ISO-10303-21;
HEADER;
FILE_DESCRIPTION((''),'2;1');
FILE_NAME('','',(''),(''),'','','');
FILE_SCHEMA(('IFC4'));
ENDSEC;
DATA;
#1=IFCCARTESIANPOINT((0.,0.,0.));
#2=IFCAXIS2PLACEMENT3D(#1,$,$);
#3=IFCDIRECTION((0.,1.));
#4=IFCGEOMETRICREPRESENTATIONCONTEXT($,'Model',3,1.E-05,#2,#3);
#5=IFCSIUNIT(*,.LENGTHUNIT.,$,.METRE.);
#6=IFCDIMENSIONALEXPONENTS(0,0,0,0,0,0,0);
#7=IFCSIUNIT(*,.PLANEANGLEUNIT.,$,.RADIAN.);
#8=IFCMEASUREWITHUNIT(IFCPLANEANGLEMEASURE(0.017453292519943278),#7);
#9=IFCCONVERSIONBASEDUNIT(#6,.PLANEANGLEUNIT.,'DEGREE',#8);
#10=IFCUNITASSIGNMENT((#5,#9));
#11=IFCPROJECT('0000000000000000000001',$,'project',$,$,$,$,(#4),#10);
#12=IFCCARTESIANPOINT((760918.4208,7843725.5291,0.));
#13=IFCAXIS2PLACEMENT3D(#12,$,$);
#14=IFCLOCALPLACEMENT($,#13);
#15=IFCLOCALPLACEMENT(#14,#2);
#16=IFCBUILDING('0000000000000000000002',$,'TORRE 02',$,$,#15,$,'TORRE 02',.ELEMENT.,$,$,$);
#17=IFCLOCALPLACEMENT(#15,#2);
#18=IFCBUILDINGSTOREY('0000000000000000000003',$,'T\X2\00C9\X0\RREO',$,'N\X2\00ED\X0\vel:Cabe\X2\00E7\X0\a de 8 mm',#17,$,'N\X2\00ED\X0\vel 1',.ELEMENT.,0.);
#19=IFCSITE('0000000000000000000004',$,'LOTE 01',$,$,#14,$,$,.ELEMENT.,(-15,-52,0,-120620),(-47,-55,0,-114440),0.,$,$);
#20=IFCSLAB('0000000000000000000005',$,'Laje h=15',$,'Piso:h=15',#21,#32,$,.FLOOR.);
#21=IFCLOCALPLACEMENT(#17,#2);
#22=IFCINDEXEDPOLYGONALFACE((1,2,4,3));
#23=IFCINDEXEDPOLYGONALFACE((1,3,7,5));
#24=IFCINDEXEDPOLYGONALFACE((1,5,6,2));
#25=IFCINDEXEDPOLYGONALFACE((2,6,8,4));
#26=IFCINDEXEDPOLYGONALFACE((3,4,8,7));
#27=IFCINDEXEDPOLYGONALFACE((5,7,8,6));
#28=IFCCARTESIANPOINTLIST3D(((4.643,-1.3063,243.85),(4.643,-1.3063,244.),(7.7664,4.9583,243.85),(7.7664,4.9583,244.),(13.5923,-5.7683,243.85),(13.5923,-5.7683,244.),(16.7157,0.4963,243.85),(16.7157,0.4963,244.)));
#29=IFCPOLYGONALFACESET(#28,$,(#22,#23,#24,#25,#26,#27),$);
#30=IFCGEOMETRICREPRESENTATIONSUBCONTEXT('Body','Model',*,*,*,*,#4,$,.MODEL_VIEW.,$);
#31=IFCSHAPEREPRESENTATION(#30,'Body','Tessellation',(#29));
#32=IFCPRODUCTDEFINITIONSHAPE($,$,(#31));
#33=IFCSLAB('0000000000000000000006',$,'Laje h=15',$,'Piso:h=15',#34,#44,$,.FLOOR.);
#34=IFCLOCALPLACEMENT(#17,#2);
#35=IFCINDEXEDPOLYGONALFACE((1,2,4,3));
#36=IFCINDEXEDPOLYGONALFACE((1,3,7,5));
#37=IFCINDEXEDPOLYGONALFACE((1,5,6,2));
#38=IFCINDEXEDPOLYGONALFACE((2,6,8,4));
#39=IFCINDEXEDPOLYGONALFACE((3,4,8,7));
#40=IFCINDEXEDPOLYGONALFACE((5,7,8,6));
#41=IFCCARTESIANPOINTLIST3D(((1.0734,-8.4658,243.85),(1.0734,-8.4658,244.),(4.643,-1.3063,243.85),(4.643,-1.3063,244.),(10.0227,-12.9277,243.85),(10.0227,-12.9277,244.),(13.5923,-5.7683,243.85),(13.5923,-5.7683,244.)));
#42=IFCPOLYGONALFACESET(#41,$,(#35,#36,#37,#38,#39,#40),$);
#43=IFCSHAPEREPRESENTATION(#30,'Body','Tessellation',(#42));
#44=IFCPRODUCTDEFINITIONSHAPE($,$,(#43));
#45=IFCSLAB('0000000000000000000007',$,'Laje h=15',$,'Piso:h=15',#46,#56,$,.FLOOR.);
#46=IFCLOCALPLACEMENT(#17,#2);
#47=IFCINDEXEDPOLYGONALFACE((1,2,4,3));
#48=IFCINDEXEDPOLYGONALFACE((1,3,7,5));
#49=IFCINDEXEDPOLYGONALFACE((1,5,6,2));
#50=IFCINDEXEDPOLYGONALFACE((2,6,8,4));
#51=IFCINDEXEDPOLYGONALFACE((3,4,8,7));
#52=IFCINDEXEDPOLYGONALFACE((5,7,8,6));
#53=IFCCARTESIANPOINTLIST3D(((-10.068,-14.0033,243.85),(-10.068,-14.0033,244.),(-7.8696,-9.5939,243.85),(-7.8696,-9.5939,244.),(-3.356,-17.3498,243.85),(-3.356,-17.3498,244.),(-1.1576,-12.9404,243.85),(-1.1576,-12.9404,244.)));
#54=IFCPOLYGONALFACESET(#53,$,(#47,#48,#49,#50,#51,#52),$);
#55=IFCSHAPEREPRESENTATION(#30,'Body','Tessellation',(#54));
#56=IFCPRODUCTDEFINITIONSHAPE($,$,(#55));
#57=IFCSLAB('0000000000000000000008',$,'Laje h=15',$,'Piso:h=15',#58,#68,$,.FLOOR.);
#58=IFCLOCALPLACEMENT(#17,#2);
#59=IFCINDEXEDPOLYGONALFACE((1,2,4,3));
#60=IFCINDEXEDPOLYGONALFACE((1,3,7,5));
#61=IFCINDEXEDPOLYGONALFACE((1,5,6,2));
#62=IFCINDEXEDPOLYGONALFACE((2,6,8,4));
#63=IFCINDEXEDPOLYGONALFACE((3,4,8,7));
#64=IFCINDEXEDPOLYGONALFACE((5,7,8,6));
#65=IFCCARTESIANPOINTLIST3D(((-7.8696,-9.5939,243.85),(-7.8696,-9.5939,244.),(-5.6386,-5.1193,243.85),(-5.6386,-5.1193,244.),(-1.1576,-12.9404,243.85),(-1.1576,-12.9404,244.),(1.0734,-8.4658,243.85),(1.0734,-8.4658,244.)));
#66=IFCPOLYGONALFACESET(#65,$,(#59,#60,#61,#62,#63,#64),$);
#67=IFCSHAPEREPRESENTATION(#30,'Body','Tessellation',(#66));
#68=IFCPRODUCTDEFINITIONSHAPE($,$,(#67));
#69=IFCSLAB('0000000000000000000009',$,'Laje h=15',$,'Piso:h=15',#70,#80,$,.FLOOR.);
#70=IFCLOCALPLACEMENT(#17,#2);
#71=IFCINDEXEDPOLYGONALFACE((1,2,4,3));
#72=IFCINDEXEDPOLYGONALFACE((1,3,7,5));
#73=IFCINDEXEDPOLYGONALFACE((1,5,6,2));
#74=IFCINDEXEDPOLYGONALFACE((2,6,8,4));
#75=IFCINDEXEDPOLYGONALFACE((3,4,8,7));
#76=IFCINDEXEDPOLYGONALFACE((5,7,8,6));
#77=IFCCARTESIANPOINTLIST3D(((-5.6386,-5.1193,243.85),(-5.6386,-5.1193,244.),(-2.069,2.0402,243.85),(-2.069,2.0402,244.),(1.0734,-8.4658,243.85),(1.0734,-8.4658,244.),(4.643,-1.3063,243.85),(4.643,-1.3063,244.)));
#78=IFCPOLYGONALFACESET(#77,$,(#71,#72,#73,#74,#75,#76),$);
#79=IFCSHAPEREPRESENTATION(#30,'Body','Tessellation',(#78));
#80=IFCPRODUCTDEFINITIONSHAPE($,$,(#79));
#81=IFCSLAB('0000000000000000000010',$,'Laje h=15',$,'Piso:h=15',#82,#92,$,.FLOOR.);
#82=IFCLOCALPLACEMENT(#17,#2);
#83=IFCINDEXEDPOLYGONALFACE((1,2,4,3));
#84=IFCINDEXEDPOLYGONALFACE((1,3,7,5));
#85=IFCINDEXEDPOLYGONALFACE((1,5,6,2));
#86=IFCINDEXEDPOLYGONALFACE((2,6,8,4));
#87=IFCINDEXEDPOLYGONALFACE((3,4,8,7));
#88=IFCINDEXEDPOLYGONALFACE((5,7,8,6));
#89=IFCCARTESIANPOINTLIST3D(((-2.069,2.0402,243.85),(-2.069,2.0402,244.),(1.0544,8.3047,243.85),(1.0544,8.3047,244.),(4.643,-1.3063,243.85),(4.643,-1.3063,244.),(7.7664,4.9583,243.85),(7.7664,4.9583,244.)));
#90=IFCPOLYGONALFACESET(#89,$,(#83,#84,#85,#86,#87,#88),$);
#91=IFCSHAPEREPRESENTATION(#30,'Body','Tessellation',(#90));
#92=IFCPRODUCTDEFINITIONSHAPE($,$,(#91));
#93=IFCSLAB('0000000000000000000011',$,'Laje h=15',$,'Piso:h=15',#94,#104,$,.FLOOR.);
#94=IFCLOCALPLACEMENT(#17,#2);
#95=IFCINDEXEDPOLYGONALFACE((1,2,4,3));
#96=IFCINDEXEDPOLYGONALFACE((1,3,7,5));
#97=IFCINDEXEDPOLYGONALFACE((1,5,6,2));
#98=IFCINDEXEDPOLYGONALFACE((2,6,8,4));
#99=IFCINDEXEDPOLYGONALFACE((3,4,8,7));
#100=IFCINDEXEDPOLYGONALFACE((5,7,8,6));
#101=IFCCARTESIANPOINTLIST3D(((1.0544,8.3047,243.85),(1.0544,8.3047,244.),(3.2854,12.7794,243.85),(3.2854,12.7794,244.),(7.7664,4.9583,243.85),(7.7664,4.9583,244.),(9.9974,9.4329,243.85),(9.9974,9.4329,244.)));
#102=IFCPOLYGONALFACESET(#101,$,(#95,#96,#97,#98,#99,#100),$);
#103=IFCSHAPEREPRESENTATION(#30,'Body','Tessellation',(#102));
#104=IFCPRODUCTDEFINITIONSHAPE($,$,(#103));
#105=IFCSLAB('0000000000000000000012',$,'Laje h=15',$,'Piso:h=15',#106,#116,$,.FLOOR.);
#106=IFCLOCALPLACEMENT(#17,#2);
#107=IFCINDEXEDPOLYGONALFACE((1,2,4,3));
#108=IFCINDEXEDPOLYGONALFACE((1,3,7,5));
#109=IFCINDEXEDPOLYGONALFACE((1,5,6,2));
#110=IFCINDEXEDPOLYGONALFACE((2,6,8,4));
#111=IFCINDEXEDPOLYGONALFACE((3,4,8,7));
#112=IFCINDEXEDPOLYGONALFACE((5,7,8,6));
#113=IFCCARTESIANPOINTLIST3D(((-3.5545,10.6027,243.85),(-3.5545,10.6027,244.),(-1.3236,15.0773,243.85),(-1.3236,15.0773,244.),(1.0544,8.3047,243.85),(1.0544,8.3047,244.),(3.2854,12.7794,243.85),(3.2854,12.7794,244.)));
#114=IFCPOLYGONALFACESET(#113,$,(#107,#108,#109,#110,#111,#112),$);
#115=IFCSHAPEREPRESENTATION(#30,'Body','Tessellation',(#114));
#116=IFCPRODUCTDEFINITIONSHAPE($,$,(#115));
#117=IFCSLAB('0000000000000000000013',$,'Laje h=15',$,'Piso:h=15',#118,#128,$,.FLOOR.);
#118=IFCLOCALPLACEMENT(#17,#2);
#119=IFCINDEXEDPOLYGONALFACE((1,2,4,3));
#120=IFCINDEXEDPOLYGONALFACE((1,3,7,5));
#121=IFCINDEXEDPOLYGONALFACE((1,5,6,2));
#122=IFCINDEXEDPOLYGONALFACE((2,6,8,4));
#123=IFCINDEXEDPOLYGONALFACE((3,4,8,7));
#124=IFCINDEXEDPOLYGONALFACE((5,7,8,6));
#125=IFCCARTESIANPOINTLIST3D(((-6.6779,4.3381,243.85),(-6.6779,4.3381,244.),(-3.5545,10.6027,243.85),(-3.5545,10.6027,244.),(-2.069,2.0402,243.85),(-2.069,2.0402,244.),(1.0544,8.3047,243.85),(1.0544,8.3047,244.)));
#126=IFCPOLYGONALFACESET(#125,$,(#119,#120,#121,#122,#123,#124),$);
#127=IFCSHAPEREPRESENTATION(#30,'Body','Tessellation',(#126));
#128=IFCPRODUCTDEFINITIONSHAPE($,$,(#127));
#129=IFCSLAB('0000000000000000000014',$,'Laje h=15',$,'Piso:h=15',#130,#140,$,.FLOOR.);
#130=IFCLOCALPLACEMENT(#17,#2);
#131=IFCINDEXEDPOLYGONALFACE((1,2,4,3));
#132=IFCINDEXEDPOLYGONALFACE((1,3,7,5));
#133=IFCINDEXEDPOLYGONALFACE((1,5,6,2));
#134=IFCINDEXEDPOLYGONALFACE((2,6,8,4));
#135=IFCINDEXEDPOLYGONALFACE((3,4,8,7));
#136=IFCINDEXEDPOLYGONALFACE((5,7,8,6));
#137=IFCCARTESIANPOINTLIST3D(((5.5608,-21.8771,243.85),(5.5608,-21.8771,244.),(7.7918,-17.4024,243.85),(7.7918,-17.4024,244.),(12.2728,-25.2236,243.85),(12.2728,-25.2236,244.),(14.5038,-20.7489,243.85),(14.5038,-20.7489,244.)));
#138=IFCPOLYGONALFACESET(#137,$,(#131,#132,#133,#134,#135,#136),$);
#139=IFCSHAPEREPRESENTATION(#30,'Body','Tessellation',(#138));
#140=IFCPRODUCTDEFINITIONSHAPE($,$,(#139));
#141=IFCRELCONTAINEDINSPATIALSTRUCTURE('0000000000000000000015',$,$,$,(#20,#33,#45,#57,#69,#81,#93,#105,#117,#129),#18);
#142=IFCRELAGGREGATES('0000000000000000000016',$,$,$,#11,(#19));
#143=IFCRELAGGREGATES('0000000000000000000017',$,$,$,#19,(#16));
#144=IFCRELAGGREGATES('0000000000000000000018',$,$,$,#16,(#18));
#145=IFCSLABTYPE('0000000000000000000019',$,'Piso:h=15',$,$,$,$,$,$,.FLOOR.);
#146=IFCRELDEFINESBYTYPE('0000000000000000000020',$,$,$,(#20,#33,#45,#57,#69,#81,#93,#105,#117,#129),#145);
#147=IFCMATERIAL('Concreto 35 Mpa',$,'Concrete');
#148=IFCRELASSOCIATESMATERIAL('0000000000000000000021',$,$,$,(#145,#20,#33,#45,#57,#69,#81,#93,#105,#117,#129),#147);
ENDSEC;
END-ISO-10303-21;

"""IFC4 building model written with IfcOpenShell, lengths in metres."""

from ifc_helpers import new_model, entity, si_unit, converted_unit, direction, frame, origin, place, context, subcontext, project, spatial, indexed_curve, outline, extrude, material, type_object, element, save


model = new_model("IFC4")

# Units and contexts
model_context = context("Model", 3, precision=1e-05, world=origin(), true_north=direction((0.0, 1.0)))
body_context = subcontext(model_context, "Body", "Model", "MODEL_VIEW")
ifc_project = project(units=[si_unit("LENGTHUNIT", "METRE"), converted_unit("PLANEANGLEUNIT", "DEGREE", entity("IfcPlaneAngleMeasure", 0.017453292519943278), si_unit("PLANEANGLEUNIT", "RADIAN"), dimensions=[0, 0, 0, 0, 0, 0, 0])], contexts=[model_context])

# Site, building, storey
site_placement = place(None, frame((760918.4208, 7843725.5291, 0.0)))
site = spatial("IfcSite", under=ifc_project, at=site_placement, Name="LOTE 01", CompositionType="ELEMENT", RefLatitude=(-15, -52, 0, -120620), RefLongitude=(-47, -55, 0, -114440), RefElevation=0.0)
building_placement = place(site_placement, origin())
building = spatial("IfcBuilding", under=site, at=building_placement, Name="TORRE 02", LongName="TORRE 02", CompositionType="ELEMENT")
storey_placement = place(building_placement, origin())
storey = spatial("IfcBuildingStorey", under=building, at=storey_placement, Name="TÉRREO", ObjectType="Nível:Cabeça de 8 mm", LongName="Nível 1", CompositionType="ELEMENT", Elevation=0.0)

# Shared definitions
placement = place(building_placement, frame((0.0, 0.0, 244.0)))

# Slabs
ifc_material_1 = material(Name="Concreto 35 Mpa", Category="Concrete")
slab_type_1 = type_object("IfcSlabType", Name="Piso:h=15", PredefinedType="FLOOR", material=ifc_material_1)
slab_1_placement = place(placement, origin())
element("IfcSlab", 1, at=slab_1_placement, inside=storey, type_object=slab_type_1, material=ifc_material_1, Name="Laje h=15", ObjectType="Piso:h=15", PredefinedType="FLOOR", context=body_context, shape_type="SweptSolid", body=[
    extrude(outline(indexed_curve([(-3.5, -5.0), (3.5, -5.0), (3.5, 5.0), (-3.5, 5.0), (-3.5, -5.0)], self_intersect=False)), frame((10.6794, -0.405, 0.0), z_axis=(0.0, 0.0, -1.0), x_axis=(-0.446198, -0.894934, 0.0)), (0.0, 0.0, 1.0), 0.15),
])
slab_2_placement = place(placement, origin())
element("IfcSlab", 2, at=slab_2_placement, inside=storey, type_object=slab_type_1, material=ifc_material_1, Name="Laje h=15", ObjectType="Piso:h=15", PredefinedType="FLOOR", context=body_context, shape_type="SweptSolid", body=[
    extrude(outline(indexed_curve([(-4.0, -5.0), (4.0, -5.0), (4.0, 5.0), (-4.0, 5.0), (-4.0, -5.0)], self_intersect=False)), frame((7.3329, -7.117, 0.0), z_axis=(0.0, 0.0, -1.0), x_axis=(-0.446198, -0.894934, 0.0)), (0.0, 0.0, 1.0), 0.15),
])
slab_3_placement = place(placement, origin())
element("IfcSlab", 3, at=slab_3_placement, inside=storey, type_object=slab_type_1, material=ifc_material_1, Name="Laje h=15", ObjectType="Piso:h=15", PredefinedType="FLOOR", context=body_context, shape_type="SweptSolid", body=[
    extrude(outline(indexed_curve([(-2.4635, -3.75), (2.4635, -3.75), (2.4635, 3.75), (-2.4635, 3.75), (-2.4635, -3.75)], self_intersect=False)), frame((-5.6128, -13.4719, 0.0), z_axis=(0.0, 0.0, -1.0), x_axis=(-0.446198, -0.894934, 0.0)), (0.0, 0.0, 1.0), 0.15),
])
slab_4_placement = place(placement, origin())
element("IfcSlab", 4, at=slab_4_placement, inside=storey, type_object=slab_type_1, material=ifc_material_1, Name="Laje h=15", ObjectType="Piso:h=15", PredefinedType="FLOOR", context=body_context, shape_type="SweptSolid", body=[
    extrude(outline(indexed_curve([(-2.5, -3.75), (2.5, -3.75), (2.5, 3.75), (-2.5, 3.75), (-2.5, -3.75)], self_intersect=False)), frame((-3.3981, -9.0298, 0.0), z_axis=(0.0, 0.0, -1.0), x_axis=(-0.446198, -0.894934, 0.0)), (0.0, 0.0, 1.0), 0.15),
])
slab_5_placement = place(placement, origin())
element("IfcSlab", 5, at=slab_5_placement, inside=storey, type_object=slab_type_1, material=ifc_material_1, Name="Laje h=15", ObjectType="Piso:h=15", PredefinedType="FLOOR", context=body_context, shape_type="SweptSolid", body=[
    extrude(outline(indexed_curve([(-4.0, -3.75), (4.0, -3.75), (4.0, 3.75), (-4.0, 3.75), (-4.0, -3.75)], self_intersect=False)), frame((-0.4978, -3.2128, 0.0), z_axis=(0.0, 0.0, -1.0), x_axis=(-0.446198, -0.894934, 0.0)), (0.0, 0.0, 1.0), 0.15),
])
slab_6_placement = place(placement, origin())
element("IfcSlab", 6, at=slab_6_placement, inside=storey, type_object=slab_type_1, material=ifc_material_1, Name="Laje h=15", ObjectType="Piso:h=15", PredefinedType="FLOOR", context=body_context, shape_type="SweptSolid", body=[
    extrude(outline(indexed_curve([(-3.5, -3.75), (3.5, -3.75), (3.5, 3.75), (-3.5, 3.75), (-3.5, -3.75)], self_intersect=False)), frame((2.8487, 3.4992, 0.0), z_axis=(0.0, 0.0, -1.0), x_axis=(-0.446198, -0.894934, 0.0)), (0.0, 0.0, 1.0), 0.15),
])
slab_7_placement = place(placement, origin())
element("IfcSlab", 7, at=slab_7_placement, inside=storey, type_object=slab_type_1, material=ifc_material_1, Name="Laje h=15", ObjectType="Piso:h=15", PredefinedType="FLOOR", context=body_context, shape_type="SweptSolid", body=[
    extrude(outline(indexed_curve([(-2.5, -3.75), (2.5, -3.75), (2.5, 3.75), (-2.5, 3.75), (-2.5, -3.75)], self_intersect=False)), frame((5.5259, 8.8688, 0.0), z_axis=(0.0, 0.0, -1.0), x_axis=(-0.446198, -0.894934, 0.0)), (0.0, 0.0, 1.0), 0.15),
])
slab_8_placement = place(placement, origin())
element("IfcSlab", 8, at=slab_8_placement, inside=storey, type_object=slab_type_1, material=ifc_material_1, Name="Laje h=15", ObjectType="Piso:h=15", PredefinedType="FLOOR", context=body_context, shape_type="SweptSolid", body=[
    extrude(outline(indexed_curve([(-2.5, -2.575), (2.5, -2.575), (2.5, 2.575), (-2.5, 2.575), (-2.5, -2.575)], self_intersect=False)), frame((-0.1346, 11.691, 0.0), z_axis=(0.0, 0.0, -1.0), x_axis=(-0.446198, -0.894934, 0.0)), (0.0, 0.0, 1.0), 0.15),
])
slab_9_placement = place(placement, origin())
element("IfcSlab", 9, at=slab_9_placement, inside=storey, type_object=slab_type_1, material=ifc_material_1, Name="Laje h=15", ObjectType="Piso:h=15", PredefinedType="FLOOR", context=body_context, shape_type="SweptSolid", body=[
    extrude(outline(indexed_curve([(-3.5, -2.575), (3.5, -2.575), (3.5, 2.575), (-3.5, 2.575), (-3.5, -2.575)], self_intersect=False)), frame((-2.8118, 6.3214, 0.0), z_axis=(0.0, 0.0, -1.0), x_axis=(-0.446198, -0.894934, 0.0)), (0.0, 0.0, 1.0), 0.15),
])
slab_10_placement = place(placement, origin())
element("IfcSlab", 10, at=slab_10_placement, inside=storey, type_object=slab_type_1, material=ifc_material_1, Name="Laje h=15", ObjectType="Piso:h=15", PredefinedType="FLOOR", context=body_context, shape_type="SweptSolid", body=[
    extrude(outline(indexed_curve([(-2.5, -3.75), (2.5, -3.75), (2.5, 3.75), (-2.5, 3.75), (-2.5, -3.75)], self_intersect=False)), frame((10.0323, -21.313, 0.0), z_axis=(0.0, 0.0, -1.0), x_axis=(-0.446198, -0.894934, 0.0)), (0.0, 0.0, 1.0), 0.15),
])

save(model, "model.ifc")
